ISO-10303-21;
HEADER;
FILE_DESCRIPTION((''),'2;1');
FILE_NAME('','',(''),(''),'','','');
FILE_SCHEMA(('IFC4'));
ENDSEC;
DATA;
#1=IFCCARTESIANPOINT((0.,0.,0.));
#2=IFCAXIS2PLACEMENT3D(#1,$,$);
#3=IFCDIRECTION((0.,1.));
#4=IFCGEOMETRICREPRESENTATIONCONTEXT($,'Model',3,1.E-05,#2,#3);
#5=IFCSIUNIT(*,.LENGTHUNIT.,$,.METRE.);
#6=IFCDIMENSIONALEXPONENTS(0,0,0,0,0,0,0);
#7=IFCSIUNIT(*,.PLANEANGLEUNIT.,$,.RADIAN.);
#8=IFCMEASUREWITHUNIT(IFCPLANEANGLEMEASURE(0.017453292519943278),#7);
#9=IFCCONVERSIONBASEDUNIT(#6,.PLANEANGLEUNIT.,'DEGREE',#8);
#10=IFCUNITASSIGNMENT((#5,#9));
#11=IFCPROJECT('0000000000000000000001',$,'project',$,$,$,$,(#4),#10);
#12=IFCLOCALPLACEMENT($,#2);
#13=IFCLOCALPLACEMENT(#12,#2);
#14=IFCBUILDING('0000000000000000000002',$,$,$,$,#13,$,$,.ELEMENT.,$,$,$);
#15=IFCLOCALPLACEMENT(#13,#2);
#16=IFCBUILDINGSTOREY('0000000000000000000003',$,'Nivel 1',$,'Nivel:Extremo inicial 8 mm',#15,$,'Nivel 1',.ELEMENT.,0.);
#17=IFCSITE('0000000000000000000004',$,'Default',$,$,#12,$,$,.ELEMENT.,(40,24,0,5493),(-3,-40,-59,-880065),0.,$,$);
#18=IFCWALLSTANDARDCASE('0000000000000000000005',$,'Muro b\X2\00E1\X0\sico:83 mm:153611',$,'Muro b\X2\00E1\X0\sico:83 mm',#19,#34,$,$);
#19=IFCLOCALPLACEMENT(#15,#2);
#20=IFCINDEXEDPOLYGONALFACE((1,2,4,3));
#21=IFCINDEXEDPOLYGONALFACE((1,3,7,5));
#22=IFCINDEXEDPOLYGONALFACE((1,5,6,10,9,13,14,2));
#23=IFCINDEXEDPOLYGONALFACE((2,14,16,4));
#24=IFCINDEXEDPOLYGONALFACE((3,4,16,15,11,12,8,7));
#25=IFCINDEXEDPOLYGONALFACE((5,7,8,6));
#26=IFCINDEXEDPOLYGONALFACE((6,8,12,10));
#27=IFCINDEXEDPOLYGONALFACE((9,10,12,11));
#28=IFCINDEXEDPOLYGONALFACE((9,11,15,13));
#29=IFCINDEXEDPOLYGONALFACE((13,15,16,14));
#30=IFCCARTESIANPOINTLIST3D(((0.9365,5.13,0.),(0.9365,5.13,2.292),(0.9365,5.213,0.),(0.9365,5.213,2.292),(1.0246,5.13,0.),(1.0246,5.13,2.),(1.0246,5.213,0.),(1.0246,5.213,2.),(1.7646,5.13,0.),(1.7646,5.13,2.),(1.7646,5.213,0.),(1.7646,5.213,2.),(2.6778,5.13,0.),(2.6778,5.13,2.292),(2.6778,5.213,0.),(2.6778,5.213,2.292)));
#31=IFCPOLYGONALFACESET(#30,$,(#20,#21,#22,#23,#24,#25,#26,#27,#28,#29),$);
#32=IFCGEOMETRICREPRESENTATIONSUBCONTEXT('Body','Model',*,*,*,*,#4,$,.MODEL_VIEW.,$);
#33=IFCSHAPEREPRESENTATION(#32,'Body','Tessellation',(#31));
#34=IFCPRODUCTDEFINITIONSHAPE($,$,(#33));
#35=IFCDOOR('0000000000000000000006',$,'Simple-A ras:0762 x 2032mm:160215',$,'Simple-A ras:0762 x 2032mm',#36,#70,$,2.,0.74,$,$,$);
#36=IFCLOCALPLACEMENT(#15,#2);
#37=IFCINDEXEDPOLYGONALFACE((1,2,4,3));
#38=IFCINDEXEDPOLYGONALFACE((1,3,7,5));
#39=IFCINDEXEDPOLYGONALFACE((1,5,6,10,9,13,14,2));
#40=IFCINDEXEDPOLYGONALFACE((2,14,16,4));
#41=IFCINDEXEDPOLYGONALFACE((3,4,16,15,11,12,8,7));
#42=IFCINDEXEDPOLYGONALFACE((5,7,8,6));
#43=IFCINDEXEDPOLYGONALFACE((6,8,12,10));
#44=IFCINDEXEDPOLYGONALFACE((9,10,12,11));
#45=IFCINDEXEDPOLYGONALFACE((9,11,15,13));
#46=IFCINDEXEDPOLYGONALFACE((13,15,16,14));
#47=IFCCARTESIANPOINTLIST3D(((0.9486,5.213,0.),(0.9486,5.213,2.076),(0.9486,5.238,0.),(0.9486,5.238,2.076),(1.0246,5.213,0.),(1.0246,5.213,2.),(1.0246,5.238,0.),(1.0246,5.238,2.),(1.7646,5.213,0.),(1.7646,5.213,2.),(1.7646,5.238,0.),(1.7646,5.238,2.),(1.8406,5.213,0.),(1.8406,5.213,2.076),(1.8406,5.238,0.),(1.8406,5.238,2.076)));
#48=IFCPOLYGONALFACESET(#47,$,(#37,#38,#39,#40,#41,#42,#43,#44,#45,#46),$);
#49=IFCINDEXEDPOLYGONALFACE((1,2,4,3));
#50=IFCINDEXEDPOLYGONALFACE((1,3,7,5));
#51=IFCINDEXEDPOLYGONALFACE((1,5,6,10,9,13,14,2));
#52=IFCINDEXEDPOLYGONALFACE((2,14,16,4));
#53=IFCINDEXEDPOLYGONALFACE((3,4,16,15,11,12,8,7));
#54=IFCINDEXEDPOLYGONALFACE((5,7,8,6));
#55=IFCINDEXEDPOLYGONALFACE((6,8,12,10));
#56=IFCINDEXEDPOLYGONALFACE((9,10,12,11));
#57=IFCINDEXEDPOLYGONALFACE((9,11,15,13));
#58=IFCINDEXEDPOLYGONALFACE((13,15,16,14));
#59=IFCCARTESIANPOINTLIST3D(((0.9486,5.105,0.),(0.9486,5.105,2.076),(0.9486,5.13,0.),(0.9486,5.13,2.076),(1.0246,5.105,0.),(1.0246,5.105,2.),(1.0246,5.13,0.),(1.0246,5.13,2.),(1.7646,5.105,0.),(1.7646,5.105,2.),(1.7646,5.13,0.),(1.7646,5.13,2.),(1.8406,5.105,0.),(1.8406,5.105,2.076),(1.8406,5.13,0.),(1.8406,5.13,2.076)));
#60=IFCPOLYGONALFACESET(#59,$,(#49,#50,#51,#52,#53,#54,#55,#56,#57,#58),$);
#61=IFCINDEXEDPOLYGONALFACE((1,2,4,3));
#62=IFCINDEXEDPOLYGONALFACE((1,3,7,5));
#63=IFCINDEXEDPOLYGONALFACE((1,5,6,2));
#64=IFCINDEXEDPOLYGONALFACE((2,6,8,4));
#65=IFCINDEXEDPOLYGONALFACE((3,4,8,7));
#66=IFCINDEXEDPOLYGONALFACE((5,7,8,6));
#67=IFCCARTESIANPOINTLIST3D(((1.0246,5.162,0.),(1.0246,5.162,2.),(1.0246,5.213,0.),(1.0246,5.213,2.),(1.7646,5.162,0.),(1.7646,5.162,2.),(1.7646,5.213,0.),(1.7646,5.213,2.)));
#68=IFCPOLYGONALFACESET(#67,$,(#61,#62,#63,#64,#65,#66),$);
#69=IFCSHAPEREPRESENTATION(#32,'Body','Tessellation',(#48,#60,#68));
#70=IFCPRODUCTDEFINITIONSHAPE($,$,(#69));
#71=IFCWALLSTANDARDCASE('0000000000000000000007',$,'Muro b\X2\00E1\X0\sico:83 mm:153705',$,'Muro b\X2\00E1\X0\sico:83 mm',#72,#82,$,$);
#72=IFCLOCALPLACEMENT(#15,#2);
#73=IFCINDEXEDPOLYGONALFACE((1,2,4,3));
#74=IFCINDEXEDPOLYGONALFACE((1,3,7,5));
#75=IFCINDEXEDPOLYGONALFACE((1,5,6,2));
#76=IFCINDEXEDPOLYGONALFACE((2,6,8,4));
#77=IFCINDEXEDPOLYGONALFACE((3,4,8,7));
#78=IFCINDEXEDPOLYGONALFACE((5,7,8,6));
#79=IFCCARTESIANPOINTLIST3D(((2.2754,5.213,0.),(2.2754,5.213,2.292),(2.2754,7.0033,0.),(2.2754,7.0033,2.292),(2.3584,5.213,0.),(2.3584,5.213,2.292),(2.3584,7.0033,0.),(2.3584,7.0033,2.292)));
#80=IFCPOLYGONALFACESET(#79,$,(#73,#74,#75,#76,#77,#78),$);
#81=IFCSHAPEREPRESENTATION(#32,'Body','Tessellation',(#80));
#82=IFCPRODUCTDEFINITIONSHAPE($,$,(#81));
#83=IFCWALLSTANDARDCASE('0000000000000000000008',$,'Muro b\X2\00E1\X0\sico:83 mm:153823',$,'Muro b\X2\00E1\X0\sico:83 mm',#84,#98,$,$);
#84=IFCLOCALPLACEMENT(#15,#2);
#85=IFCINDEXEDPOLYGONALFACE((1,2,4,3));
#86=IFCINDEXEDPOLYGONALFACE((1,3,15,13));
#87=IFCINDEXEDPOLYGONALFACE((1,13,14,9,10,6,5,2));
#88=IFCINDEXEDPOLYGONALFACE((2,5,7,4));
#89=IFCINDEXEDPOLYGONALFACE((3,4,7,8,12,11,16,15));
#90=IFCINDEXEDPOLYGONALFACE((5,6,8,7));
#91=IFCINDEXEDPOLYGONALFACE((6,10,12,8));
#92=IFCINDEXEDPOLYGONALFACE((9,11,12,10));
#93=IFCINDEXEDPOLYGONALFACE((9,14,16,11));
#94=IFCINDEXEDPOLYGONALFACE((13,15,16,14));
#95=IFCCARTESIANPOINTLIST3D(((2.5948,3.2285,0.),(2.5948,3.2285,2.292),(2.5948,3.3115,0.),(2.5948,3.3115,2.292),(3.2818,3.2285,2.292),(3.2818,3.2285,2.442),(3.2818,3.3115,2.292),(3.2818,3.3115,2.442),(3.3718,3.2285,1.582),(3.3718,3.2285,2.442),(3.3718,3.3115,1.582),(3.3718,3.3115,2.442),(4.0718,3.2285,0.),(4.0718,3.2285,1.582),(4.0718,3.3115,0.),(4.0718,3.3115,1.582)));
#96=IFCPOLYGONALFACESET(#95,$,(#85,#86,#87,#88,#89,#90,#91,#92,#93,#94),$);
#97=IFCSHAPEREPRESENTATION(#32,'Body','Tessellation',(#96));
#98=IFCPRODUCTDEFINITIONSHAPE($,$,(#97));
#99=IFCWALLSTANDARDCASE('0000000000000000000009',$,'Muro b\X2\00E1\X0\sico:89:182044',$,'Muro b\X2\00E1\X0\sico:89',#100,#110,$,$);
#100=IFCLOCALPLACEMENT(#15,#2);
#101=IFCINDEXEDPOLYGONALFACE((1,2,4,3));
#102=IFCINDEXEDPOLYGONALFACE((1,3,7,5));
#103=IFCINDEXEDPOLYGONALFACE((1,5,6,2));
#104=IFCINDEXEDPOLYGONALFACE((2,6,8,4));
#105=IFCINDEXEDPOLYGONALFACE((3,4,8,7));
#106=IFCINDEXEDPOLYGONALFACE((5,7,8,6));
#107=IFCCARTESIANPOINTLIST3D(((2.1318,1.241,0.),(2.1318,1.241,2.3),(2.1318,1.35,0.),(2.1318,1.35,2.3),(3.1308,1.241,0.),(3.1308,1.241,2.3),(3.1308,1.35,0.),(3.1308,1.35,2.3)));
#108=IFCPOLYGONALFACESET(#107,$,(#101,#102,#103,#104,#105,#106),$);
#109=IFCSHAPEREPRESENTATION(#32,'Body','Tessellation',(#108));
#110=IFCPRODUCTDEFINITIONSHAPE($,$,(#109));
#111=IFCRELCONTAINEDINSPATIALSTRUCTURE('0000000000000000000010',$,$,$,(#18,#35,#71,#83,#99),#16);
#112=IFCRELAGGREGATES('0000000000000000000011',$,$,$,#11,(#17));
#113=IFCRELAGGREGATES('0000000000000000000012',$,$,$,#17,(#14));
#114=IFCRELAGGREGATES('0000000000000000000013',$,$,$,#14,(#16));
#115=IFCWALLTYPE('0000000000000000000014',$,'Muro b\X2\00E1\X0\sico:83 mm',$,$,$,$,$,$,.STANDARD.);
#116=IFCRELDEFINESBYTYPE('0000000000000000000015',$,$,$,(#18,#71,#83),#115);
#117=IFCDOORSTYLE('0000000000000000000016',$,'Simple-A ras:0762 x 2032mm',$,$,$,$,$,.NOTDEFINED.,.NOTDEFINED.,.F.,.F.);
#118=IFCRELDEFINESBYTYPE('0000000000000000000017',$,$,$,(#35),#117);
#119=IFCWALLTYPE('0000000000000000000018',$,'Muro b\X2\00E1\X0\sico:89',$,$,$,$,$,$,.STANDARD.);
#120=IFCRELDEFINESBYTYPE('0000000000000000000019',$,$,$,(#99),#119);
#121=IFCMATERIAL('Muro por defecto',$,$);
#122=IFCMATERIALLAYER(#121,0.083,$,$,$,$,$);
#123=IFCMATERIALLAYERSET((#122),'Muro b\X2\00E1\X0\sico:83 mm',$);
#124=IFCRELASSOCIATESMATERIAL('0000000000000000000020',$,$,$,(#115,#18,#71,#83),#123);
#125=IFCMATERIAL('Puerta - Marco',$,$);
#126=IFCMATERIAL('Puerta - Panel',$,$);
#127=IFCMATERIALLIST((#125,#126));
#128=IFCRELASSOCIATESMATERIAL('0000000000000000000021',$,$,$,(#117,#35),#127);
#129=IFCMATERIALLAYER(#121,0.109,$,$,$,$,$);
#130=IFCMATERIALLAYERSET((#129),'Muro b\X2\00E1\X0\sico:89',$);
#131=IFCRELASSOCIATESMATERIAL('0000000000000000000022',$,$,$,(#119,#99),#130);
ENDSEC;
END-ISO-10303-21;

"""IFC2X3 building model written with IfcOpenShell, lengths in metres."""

from ifc_helpers import new_model, entity, si_unit, converted_unit, direction, frame, frame_2d, origin, origin_2d_with_axis, place, context, subcontext, project, spatial, polyline, rectangle, outline, extrude, clip, bounded_halfspace, source, transform, mapped, material, material_list, layer, layer_set, layer_usage, type_object, type_shapes, element, fill, save


model = new_model("IFC2X3")

# Units and contexts
model_context = context("Model", 3, precision=1e-05, world=origin(), true_north=direction((0.0, 1.0)))
body_context = subcontext(model_context, "Body", "Model", "MODEL_VIEW")
ifc_project = project(units=[si_unit("LENGTHUNIT", "METRE"), converted_unit("PLANEANGLEUNIT", "DEGREE", entity("IfcPlaneAngleMeasure", 0.017453292519943278), si_unit("PLANEANGLEUNIT", "RADIAN"), dimensions=[0, 0, 0, 0, 0, 0, 0])], contexts=[model_context])

# Site, building, storey
site_placement = place(None, origin())
site = spatial("IfcSite", under=ifc_project, at=site_placement, Name="Default", CompositionType="ELEMENT", RefLatitude=(40, 24, 0, 5493), RefLongitude=(-3, -40, -59, -880065), RefElevation=0.0)
building_placement = place(site_placement, origin())
building = spatial("IfcBuilding", under=site, at=building_placement, CompositionType="ELEMENT")
storey_placement = place(building_placement, origin())
storey = spatial("IfcBuildingStorey", under=building, at=storey_placement, Name="Nivel 1", ObjectType="Nivel:Extremo inicial 8 mm", LongName="Nivel 1", CompositionType="ELEMENT", Elevation=0.0)

# Shared definitions
ifc_material_1 = material(Name="Muro por defecto")

# Shared definitions
ifc_material_2 = material(Name="Puerta - Marco")
ifc_material_3 = material(Name="Puerta - Panel")
ifc_material_list_1 = material_list([ifc_material_2, ifc_material_3])

# Shared definitions
ifc_layer_1 = layer(ifc_material_1, 0.083)
ifc_layer_set_1 = layer_set([ifc_layer_1], Name="Muro básico:83 mm")
wall_type_1 = type_object("IfcWallType", Name="Muro básico:83 mm", PredefinedType="STANDARD", material=ifc_layer_set_1)

# Wall, openings, door
ifc_layer_usage_1 = layer_usage(ifc_layer_set_1, "AXIS2", "NEGATIVE", 0.0415)
wall_1_placement = place(storey_placement, frame((0.9365, 5.1715, 0.0)))
wall_1 = element("IfcWallStandardCase", 1, at=wall_1_placement, inside=storey, type_object=wall_type_1, material=ifc_layer_usage_1, Name="Muro básico:83 mm:153611", ObjectType="Muro básico:83 mm", context=body_context, shape_type="Clipping", body=[
    clip(extrude(rectangle(XDim=1.7413, YDim=0.083, at=frame_2d((0.8706, 0.0), x_axis=(-1.0, 0.0))), origin(), (0.0, 0.0, 1.0), 2.292), bounded_halfspace(frame((0.0, -0.0415, 2.292), z_axis=(0.0, 0.0, -1.0), x_axis=(1.0, 0.0, 0.0)), True, frame((0.0, -0.0415, 2.292)), polyline([(0.0, 0.0), (1.6583, 0.0), (1.7413, 0.0), (1.7413, 0.083), (1.4219, 0.083), (1.3389, 0.083), (0.0, 0.083), (0.0, 0.0)]))),
])
opening_1_placement = place(wall_1_placement, frame((-0.9365, -5.1715, 0.0)))
element("IfcOpeningElement", 2, at=opening_1_placement, cuts=wall_1, ObjectType="Opening", context=body_context, shape_type="SweptSolid", body=[
    extrude(rectangle(XDim=2.0, YDim=0.083, at=frame_2d((0.0, 0.0), x_axis=(0.0, 1.0))), frame((2.6363, 4.39, 1.0), z_axis=(0.0, 1.0, 0.0), x_axis=(-1.0, 0.0, 0.0)), (0.0, 0.0, 1.0), 0.74),
])
opening_2_placement = place(wall_1_placement, frame((0.0881, -0.0415, 0.0)))
opening_2 = element("IfcOpeningElement", 3, at=opening_2_placement, cuts=wall_1, ObjectType="Opening", context=body_context, shape_type="SweptSolid", body=[
    extrude(rectangle(XDim=0.74, YDim=2.0, at=frame_2d((1.0, 0.37), x_axis=(0.0, 1.0))), frame((0.0, 0.0, 0.0), z_axis=(0.0, 1.0, 0.0), x_axis=(0.0, 0.0, 1.0)), (0.0, 0.0, 1.0), 0.083),
])
door_style_1 = type_object("IfcDoorStyle", Name="Simple-A ras:0762 x 2032mm", ConstructionType="NOTDEFINED", OperationType="NOTDEFINED", ParameterTakesPrecedence=False, Sizeable=False, material=ifc_material_list_1)
shared_shape_1 = source(origin(), body_context, "Body", "SweptSolid", [
    extrude(outline(polyline([(-0.446, -1.057), (0.446, -1.057), (0.446, 1.019), (0.37, 1.019), (0.37, -0.981), (-0.37, -0.981), (-0.37, 1.019), (-0.446, 1.019), (-0.446, -1.057)])), frame((0.37, 0.083, 1.019), z_axis=(0.0, 1.0, 0.0), x_axis=(1.0, 0.0, 0.0)), (0.0, 0.0, 1.0), 0.025),
    extrude(outline(polyline([(-1.057, -0.446), (1.019, -0.446), (1.019, -0.37), (-0.981, -0.37), (-0.981, 0.37), (1.019, 0.37), (1.019, 0.446), (-1.057, 0.446), (-1.057, -0.446)])), frame((0.37, -0.025, 1.019), z_axis=(0.0, 1.0, 0.0), x_axis=(0.0, 0.0, -1.0)), (0.0, 0.0, 1.0), 0.025),
    extrude(rectangle(XDim=0.051, YDim=0.74, at=origin_2d_with_axis()), frame((0.37, 0.0575, 0.0), z_axis=(0.0, 0.0, 1.0), x_axis=(0.0, 1.0, 0.0)), (0.0, 0.0, 1.0), 2.0),
])
type_shapes(door_style_1, [shared_shape_1])
door_1_placement = place(opening_2_placement, origin())
door_1 = element("IfcDoor", 4, at=door_1_placement, inside=storey, type_object=door_style_1, material=ifc_material_list_1, Name="Simple-A ras:0762 x 2032mm:160215", ObjectType="Simple-A ras:0762 x 2032mm", OverallHeight=2.0, OverallWidth=0.74, context=body_context, shape_type="MappedRepresentation", body=[
    mapped(shared_shape_1, transform((0.0, 0.0, 0.0), scale=1.0)),
])
fill(opening_2, door_1)

# Wall
ifc_layer_usage_2 = layer_usage(ifc_layer_set_1, "AXIS2", "NEGATIVE", 0.0415)
wall_2_placement = place(storey_placement, frame((2.3169, 5.213, 0.0), z_axis=(0.0, 0.0, 1.0), x_axis=(0.0, 1.0, 0.0)))
element("IfcWallStandardCase", 5, at=wall_2_placement, inside=storey, type_object=wall_type_1, material=ifc_layer_usage_2, Name="Muro básico:83 mm:153705", ObjectType="Muro básico:83 mm", context=body_context, shape_type="Clipping", body=[
    clip(extrude(rectangle(XDim=1.7903, YDim=0.083, at=frame_2d((0.8951, 0.0), x_axis=(-1.0, 0.0))), origin(), (0.0, 0.0, 1.0), 2.292), bounded_halfspace(frame((0.0, -0.0415, 2.292), z_axis=(0.0, 0.0, -1.0), x_axis=(0.0, -1.0, 0.0)), True, frame((0.0, -0.0415, 2.292)), polyline([(0.0, 0.0), (1.7903, 0.0), (1.7903, 0.083), (0.0, 0.083), (0.0, 0.0)]))),
])

# Wall, opening
ifc_layer_usage_3 = layer_usage(ifc_layer_set_1, "AXIS2", "NEGATIVE", 0.0415)
wall_3_placement = place(storey_placement, frame((4.0718, 3.27, 0.0), z_axis=(0.0, 0.0, 1.0), x_axis=(-1.0, 0.0, 0.0)))
wall_3 = element("IfcWallStandardCase", 6, at=wall_3_placement, inside=storey, type_object=wall_type_1, material=ifc_layer_usage_3, Name="Muro básico:83 mm:153823", ObjectType="Muro básico:83 mm", context=body_context, shape_type="Clipping", body=[
    clip(extrude(rectangle(XDim=1.477, YDim=0.083, at=frame_2d((0.7385, 0.0), x_axis=(-1.0, 0.0))), origin(), (0.0, 0.0, 1.0), 2.442), bounded_halfspace(frame((0.79, -0.0415, 2.292), z_axis=(0.0, 0.0, -1.0), x_axis=(-1.0, 0.0, 0.0)), True, frame((0.79, -0.0415, 2.292)), polyline([(0.0, 0.0), (0.604, 0.0), (0.687, 0.0), (0.687, 0.083), (0.0, 0.083), (0.0, 0.0)]))),
])
opening_3_placement = place(wall_3_placement, origin())
element("IfcOpeningElement", 7, at=opening_3_placement, cuts=wall_3, ObjectType="Opening", context=body_context, shape_type="SweptSolid", body=[
    extrude(rectangle(XDim=0.86, YDim=0.765, at=frame_2d((0.0, 0.0), x_axis=(0.0, 1.0))), frame((0.3175, 0.0415, 2.012), z_axis=(0.0, -1.0, 0.0), x_axis=(-1.0, 0.0, 0.0)), (0.0, 0.0, 1.0), 0.083),
])

# Wall
ifc_layer_2 = layer(ifc_material_1, 0.109)
ifc_layer_set_2 = layer_set([ifc_layer_2], Name="Muro básico:89")
ifc_layer_usage_4 = layer_usage(ifc_layer_set_2, "AXIS2", "NEGATIVE", 0.0545)
wall_type_2 = type_object("IfcWallType", Name="Muro básico:89", PredefinedType="STANDARD", material=ifc_layer_set_2)
wall_4_placement = place(storey_placement, frame((3.1308, 1.2955, 0.0), z_axis=(0.0, 0.0, 1.0), x_axis=(-1.0, 0.0, 0.0)))
element("IfcWallStandardCase", 8, at=wall_4_placement, inside=storey, type_object=wall_type_2, material=ifc_layer_usage_4, Name="Muro básico:89:182044", ObjectType="Muro básico:89", context=body_context, shape_type="SweptSolid", body=[
    extrude(rectangle(XDim=0.999, YDim=0.109, at=frame_2d((0.4995, 0.0), x_axis=(-1.0, 0.0))), origin(), (0.0, 0.0, 1.0), 2.3),
])

save(model, "model.ifc")
